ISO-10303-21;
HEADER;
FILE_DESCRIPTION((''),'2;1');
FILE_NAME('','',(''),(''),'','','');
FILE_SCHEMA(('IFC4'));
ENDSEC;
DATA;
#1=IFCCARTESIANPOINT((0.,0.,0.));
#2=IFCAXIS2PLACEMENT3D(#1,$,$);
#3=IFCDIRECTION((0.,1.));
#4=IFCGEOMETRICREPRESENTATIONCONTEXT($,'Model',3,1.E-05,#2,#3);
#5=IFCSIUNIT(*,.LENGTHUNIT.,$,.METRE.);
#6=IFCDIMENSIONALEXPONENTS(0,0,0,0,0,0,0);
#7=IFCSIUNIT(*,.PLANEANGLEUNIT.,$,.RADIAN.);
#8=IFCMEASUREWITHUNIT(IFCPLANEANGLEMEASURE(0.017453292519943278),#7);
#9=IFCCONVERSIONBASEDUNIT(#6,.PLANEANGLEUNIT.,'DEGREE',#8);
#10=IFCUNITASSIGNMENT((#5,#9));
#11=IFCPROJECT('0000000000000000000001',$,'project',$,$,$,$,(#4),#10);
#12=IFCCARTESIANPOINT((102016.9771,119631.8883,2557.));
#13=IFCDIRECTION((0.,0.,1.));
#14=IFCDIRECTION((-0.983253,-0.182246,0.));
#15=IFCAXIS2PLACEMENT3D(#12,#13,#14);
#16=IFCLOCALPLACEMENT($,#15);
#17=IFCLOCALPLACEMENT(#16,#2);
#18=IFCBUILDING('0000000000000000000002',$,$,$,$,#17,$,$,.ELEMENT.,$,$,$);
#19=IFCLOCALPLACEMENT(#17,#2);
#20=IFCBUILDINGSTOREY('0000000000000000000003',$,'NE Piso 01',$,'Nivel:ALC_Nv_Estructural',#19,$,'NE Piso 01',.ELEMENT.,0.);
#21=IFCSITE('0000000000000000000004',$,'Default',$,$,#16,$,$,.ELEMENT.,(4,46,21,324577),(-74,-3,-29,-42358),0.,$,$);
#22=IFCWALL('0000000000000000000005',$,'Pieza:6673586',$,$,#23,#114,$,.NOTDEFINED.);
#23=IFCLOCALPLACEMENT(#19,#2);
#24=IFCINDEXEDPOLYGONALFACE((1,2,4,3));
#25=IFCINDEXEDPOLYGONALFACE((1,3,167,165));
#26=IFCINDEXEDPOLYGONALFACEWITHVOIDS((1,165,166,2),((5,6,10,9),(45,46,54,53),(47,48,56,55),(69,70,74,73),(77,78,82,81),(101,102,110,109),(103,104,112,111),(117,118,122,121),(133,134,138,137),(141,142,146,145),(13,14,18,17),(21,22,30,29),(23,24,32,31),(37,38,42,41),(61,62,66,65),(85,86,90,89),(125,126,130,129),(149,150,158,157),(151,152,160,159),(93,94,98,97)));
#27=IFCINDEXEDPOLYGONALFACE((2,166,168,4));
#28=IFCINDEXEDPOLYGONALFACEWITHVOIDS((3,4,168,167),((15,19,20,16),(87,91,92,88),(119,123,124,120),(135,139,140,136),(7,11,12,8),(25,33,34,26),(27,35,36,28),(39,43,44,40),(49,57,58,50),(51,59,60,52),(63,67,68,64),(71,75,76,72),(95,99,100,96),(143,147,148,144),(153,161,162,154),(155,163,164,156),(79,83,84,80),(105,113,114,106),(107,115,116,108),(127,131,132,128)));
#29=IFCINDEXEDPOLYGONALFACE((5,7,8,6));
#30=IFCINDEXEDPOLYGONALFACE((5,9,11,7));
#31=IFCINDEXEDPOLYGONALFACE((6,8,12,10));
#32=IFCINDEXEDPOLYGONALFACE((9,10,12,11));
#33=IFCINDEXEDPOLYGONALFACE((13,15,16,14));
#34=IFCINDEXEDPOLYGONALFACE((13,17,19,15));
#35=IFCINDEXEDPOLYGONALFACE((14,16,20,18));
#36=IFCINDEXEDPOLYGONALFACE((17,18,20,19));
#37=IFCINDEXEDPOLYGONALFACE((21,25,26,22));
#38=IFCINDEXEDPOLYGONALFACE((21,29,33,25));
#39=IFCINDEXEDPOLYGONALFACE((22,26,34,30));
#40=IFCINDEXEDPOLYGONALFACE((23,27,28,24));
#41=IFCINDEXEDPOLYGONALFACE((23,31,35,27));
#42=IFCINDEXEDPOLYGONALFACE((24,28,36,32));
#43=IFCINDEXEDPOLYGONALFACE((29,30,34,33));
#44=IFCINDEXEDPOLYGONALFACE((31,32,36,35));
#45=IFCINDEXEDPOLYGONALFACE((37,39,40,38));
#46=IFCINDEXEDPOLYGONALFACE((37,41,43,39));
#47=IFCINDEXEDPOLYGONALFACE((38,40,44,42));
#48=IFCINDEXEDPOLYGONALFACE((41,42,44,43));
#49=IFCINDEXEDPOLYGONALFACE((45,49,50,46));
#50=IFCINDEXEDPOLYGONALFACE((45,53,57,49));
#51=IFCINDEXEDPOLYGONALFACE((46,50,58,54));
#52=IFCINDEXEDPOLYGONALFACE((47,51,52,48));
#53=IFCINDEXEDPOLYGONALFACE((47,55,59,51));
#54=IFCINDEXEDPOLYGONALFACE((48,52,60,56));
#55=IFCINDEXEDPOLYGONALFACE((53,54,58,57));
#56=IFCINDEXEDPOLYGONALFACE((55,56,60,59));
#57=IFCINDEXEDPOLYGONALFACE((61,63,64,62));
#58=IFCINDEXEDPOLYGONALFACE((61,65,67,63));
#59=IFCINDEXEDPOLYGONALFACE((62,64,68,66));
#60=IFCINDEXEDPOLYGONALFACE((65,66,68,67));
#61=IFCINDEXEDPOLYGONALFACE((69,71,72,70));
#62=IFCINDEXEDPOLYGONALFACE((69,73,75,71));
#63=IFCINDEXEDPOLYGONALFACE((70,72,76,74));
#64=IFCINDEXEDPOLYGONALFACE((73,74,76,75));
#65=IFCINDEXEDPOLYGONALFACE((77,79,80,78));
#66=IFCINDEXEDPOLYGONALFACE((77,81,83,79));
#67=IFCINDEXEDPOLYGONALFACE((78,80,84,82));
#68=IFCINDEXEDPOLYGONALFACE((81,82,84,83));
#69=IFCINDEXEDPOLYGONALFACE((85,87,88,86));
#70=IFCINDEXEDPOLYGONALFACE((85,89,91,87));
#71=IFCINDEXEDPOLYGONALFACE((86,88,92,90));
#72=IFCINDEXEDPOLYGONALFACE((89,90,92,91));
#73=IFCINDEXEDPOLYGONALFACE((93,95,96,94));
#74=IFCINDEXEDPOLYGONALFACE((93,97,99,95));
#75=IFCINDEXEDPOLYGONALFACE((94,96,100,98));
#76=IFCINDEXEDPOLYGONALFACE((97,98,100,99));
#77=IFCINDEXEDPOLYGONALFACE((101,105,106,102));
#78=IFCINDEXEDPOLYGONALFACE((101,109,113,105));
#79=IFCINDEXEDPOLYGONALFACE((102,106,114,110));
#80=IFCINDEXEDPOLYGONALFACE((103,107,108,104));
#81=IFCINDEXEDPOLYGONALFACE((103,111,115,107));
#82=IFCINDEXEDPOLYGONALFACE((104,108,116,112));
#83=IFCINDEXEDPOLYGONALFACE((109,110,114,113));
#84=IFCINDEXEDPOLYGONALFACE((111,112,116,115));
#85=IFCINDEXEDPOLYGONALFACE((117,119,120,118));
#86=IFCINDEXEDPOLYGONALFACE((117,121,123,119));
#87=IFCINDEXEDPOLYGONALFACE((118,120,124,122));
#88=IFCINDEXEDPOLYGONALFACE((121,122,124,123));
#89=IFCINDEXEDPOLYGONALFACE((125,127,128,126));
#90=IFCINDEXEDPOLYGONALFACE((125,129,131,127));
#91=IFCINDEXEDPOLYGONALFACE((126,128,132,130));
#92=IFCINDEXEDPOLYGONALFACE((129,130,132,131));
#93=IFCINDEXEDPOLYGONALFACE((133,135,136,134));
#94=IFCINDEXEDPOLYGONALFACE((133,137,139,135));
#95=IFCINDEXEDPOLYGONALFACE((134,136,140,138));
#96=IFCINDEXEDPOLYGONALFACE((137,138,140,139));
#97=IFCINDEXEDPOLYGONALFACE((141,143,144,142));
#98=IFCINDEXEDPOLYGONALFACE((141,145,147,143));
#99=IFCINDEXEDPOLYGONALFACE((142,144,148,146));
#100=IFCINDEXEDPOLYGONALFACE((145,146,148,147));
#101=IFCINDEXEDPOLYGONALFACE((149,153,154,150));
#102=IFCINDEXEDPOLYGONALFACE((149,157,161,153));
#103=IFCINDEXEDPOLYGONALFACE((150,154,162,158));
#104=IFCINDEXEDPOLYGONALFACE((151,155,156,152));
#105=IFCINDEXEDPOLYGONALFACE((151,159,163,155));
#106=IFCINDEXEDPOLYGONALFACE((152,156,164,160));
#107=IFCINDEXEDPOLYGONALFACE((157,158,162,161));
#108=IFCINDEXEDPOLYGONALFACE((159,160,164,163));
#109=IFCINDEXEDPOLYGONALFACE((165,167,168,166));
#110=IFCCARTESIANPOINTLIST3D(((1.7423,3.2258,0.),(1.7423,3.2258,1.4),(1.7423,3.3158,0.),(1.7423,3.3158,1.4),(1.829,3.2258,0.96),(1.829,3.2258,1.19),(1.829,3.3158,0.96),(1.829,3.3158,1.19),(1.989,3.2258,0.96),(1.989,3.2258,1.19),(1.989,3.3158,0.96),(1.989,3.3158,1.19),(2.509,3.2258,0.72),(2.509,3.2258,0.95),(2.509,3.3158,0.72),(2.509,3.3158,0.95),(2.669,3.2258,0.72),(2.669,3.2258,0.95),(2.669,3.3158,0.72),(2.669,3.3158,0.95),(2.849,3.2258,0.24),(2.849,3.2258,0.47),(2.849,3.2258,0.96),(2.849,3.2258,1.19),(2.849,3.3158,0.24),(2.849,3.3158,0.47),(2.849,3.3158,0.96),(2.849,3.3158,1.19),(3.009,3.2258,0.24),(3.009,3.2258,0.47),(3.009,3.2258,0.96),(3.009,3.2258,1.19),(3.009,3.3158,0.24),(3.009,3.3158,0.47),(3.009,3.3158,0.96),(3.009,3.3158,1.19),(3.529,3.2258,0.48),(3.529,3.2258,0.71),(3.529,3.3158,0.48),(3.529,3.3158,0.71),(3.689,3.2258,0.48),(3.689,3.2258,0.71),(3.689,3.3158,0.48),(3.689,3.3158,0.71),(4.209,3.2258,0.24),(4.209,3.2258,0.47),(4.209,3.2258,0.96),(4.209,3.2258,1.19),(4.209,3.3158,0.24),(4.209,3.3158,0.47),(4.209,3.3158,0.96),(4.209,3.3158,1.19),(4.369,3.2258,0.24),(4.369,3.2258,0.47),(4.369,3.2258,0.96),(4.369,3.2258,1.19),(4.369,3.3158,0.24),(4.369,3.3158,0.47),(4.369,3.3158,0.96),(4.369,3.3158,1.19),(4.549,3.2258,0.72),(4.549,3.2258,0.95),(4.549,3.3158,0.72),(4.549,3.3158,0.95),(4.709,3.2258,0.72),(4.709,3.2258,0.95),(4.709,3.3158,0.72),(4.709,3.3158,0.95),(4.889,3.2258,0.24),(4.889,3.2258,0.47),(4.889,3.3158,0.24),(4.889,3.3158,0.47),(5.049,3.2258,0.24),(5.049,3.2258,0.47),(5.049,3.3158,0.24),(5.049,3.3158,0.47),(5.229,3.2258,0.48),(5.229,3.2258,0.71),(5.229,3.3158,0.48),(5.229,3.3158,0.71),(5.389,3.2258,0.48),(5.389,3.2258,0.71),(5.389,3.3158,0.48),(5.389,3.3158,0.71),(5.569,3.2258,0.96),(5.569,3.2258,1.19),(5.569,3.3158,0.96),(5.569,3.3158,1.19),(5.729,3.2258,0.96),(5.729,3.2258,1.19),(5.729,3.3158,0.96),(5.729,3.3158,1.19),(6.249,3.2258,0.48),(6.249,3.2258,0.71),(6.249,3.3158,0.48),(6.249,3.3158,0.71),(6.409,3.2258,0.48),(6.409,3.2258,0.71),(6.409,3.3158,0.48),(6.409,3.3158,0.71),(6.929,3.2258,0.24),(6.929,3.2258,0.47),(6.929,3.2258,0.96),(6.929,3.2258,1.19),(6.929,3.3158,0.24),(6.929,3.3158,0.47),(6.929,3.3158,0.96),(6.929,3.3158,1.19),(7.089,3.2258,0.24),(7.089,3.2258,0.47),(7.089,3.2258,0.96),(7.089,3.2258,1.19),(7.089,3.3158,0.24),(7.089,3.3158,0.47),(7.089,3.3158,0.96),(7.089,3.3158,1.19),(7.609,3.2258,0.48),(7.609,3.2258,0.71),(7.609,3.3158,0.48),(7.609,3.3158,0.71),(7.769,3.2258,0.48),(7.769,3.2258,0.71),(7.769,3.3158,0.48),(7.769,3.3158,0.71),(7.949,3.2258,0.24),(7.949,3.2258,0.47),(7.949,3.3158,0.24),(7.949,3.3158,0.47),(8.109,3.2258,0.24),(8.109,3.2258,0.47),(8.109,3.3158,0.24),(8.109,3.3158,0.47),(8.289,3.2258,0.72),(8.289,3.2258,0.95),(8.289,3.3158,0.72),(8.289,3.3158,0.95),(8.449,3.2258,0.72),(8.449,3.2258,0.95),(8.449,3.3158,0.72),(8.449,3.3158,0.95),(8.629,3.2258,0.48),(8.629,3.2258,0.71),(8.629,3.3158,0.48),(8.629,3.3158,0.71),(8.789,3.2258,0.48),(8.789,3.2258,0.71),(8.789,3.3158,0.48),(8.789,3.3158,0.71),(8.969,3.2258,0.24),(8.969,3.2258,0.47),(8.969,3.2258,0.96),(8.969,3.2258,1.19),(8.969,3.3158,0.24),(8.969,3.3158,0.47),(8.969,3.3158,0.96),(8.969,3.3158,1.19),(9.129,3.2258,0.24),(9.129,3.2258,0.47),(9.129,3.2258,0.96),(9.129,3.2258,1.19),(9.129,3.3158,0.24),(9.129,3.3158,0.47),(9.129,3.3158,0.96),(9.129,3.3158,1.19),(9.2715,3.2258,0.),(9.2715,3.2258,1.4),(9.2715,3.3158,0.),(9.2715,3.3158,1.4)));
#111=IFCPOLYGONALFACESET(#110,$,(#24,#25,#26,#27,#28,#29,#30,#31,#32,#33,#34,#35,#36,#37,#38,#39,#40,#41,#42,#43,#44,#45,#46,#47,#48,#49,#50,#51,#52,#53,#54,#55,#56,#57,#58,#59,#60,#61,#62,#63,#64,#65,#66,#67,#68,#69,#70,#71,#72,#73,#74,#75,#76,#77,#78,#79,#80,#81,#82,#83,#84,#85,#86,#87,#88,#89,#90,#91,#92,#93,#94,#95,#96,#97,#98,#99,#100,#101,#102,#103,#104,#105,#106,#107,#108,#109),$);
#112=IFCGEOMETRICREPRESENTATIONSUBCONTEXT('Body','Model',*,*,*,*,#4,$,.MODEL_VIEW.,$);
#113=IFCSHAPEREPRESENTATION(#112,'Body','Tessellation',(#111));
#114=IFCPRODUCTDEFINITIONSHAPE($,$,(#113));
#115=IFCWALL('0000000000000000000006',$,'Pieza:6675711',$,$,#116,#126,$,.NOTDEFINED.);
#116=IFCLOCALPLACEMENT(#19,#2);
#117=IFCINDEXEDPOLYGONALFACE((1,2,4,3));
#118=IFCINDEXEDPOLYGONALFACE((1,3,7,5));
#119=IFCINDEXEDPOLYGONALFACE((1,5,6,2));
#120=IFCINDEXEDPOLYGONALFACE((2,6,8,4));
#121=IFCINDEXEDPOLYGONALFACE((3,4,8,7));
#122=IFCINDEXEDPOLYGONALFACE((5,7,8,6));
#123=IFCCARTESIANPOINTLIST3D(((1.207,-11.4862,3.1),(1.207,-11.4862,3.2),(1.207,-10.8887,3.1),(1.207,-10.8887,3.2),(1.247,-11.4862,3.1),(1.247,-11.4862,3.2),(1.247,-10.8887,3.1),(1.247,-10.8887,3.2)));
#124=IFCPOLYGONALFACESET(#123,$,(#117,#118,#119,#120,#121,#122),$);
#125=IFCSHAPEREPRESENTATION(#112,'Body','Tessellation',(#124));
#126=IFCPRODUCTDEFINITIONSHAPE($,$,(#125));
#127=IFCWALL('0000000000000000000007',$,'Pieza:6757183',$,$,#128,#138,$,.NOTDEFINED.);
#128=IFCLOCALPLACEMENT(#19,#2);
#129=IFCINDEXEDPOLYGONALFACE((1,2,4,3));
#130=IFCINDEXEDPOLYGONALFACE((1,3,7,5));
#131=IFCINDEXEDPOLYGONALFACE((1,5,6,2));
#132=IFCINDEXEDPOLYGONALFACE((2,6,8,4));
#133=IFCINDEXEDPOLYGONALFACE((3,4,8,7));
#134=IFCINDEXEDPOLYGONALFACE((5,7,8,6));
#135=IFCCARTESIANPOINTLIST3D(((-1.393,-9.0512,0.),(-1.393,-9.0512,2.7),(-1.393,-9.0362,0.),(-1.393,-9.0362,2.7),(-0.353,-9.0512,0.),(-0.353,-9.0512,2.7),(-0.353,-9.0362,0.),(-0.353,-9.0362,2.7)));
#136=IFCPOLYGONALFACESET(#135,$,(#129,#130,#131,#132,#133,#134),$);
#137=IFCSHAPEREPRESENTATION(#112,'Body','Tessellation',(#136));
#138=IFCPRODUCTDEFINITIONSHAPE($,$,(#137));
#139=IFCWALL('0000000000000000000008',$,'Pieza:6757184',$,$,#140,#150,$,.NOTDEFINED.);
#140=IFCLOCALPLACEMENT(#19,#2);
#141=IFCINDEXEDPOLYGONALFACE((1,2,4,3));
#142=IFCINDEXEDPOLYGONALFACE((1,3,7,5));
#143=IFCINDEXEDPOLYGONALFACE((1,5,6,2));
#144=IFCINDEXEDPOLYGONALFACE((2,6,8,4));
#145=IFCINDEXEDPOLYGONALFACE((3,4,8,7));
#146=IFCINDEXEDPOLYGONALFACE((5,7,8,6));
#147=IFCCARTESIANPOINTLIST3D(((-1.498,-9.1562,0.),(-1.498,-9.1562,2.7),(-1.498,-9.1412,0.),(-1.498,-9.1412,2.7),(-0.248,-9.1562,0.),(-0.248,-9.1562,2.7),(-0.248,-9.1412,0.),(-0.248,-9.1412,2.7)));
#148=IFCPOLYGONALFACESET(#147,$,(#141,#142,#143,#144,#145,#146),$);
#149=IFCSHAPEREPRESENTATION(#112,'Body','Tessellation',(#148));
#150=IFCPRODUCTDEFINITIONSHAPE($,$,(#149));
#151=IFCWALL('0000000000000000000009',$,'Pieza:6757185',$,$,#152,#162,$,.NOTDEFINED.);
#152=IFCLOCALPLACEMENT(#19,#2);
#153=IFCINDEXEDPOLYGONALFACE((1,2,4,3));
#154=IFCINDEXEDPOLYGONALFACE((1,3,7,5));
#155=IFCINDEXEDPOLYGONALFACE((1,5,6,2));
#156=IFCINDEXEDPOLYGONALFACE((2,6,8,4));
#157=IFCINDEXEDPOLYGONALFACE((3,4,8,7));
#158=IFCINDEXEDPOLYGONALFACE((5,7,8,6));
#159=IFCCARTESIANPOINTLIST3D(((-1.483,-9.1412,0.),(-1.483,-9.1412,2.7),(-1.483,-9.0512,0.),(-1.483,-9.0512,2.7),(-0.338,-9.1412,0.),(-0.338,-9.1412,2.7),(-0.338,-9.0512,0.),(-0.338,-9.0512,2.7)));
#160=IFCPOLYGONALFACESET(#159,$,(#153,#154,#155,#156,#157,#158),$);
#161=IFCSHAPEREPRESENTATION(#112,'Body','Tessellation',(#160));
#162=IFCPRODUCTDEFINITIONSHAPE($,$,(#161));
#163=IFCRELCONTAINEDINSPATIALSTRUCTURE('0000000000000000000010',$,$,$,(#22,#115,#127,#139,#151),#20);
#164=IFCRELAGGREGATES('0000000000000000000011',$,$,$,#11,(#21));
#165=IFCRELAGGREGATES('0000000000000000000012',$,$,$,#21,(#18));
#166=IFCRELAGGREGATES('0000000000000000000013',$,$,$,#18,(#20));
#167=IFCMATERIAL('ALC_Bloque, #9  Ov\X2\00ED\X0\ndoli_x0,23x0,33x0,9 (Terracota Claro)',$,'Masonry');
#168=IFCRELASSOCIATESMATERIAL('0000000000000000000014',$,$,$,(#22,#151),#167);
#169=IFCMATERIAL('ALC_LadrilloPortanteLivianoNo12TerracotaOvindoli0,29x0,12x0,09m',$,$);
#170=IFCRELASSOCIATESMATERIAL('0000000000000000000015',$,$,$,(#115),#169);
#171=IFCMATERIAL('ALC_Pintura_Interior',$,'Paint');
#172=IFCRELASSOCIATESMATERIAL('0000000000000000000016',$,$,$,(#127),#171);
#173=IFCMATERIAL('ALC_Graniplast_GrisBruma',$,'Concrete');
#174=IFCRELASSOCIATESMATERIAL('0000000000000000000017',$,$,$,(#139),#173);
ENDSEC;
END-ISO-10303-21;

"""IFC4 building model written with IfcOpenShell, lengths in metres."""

from ifc_helpers import new_model, entity, si_unit, converted_unit, direction, frame, frame_2d, origin, place, context, subcontext, project, spatial, rectangle, extrude, boolean, material, element, save


model = new_model("IFC4")

# Units and contexts
model_context = context("Model", 3, precision=1e-05, world=origin(), true_north=direction((0.0, 1.0)))
body_context = subcontext(model_context, "Body", "Model", "MODEL_VIEW")
ifc_project = project(units=[si_unit("LENGTHUNIT", "METRE"), converted_unit("PLANEANGLEUNIT", "DEGREE", entity("IfcPlaneAngleMeasure", 0.017453292519943278), si_unit("PLANEANGLEUNIT", "RADIAN"), dimensions=[0, 0, 0, 0, 0, 0, 0])], contexts=[model_context])

# Site, building, storey
site_placement = place(None, frame((102016.9771, 119631.8883, 2557.0), z_axis=(0.0, 0.0, 1.0), x_axis=(-0.983253, -0.182246, 0.0)))
site = spatial("IfcSite", under=ifc_project, at=site_placement, Name="Default", CompositionType="ELEMENT", RefLatitude=(4, 46, 21, 324577), RefLongitude=(-74, -3, -29, -42358), RefElevation=0.0)
building_placement = place(site_placement, origin())
building = spatial("IfcBuilding", under=site, at=building_placement, CompositionType="ELEMENT")
storey_placement = place(building_placement, origin())
storey = spatial("IfcBuildingStorey", under=building, at=storey_placement, Name="NE Piso 01", ObjectType="Nivel:ALC_Nv_Estructural", LongName="NE Piso 01", CompositionType="ELEMENT", Elevation=0.0)

# Shared definitions
ifc_material_1 = material(Name="ALC_Pintura_Interior", Category="Paint")

# Shared definitions
ifc_material_2 = material(Name="ALC_Bloque, #9  Ovíndoli_x0,23x0,33x0,9 (Terracota Claro)", Category="Masonry")

# Walls
ifc_material_3 = material(Name="ALC_Graniplast_GrisBruma", Category="Concrete")
wall_1_placement = place(storey_placement, origin())
solid_1 = boolean("DIFFERENCE", boolean("DIFFERENCE", boolean("DIFFERENCE", boolean("DIFFERENCE", boolean("DIFFERENCE", boolean("DIFFERENCE", boolean("DIFFERENCE", boolean("DIFFERENCE", extrude(rectangle(XDim=0.09, YDim=7.5292, at=frame_2d((0.0, 0.0), x_axis=(1.0, 0.0))), frame((5.5069, 3.2708, 0.0), z_axis=(0.0, 0.0, 1.0), x_axis=(0.0, -1.0, 0.0)), (0.0, 0.0, 1.0), 1.4), extrude(rectangle(XDim=0.23, YDim=0.16, at=frame_2d((0.0, 0.0), x_axis=(0.0, 1.0))), frame((2.929, 3.3158, 0.355), z_axis=(0.0, -1.0, 0.0), x_axis=(-1.0, 0.0, 0.0)), (0.0, 0.0, 1.0), 0.09)), extrude(rectangle(XDim=0.23, YDim=0.16, at=frame_2d((0.0, 0.0), x_axis=(0.0, 1.0))), frame((4.289, 3.3158, 0.355), z_axis=(0.0, -1.0, 0.0), x_axis=(-1.0, 0.0, 0.0)), (0.0, 0.0, 1.0), 0.09)), extrude(rectangle(XDim=0.23, YDim=0.16, at=frame_2d((0.0, 0.0), x_axis=(0.0, 1.0))), frame((4.969, 3.3158, 0.355), z_axis=(0.0, -1.0, 0.0), x_axis=(-1.0, 0.0, 0.0)), (0.0, 0.0, 1.0), 0.09)), extrude(rectangle(XDim=0.23, YDim=0.16, at=frame_2d((0.0, 0.0), x_axis=(0.0, 1.0))), frame((7.009, 3.3158, 0.355), z_axis=(0.0, -1.0, 0.0), x_axis=(-1.0, 0.0, 0.0)), (0.0, 0.0, 1.0), 0.09)), extrude(rectangle(XDim=0.23, YDim=0.16, at=frame_2d((0.0, 0.0), x_axis=(0.0, 1.0))), frame((8.029, 3.3158, 0.355), z_axis=(0.0, -1.0, 0.0), x_axis=(-1.0, 0.0, 0.0)), (0.0, 0.0, 1.0), 0.09)), extrude(rectangle(XDim=0.23, YDim=0.16, at=frame_2d((0.0, 0.0), x_axis=(0.0, 1.0))), frame((9.049, 3.3158, 0.355), z_axis=(0.0, -1.0, 0.0), x_axis=(-1.0, 0.0, 0.0)), (0.0, 0.0, 1.0), 0.09)), extrude(rectangle(XDim=0.23, YDim=0.16, at=frame_2d((0.0, 0.0), x_axis=(0.0, 1.0))), frame((3.609, 3.3158, 0.595), z_axis=(0.0, -1.0, 0.0), x_axis=(-1.0, 0.0, 0.0)), (0.0, 0.0, 1.0), 0.09)), extrude(rectangle(XDim=0.23, YDim=0.16, at=frame_2d((0.0, 0.0), x_axis=(0.0, 1.0))), frame((5.309, 3.3158, 0.595), z_axis=(0.0, -1.0, 0.0), x_axis=(-1.0, 0.0, 0.0)), (0.0, 0.0, 1.0), 0.09))
solid_2 = boolean("DIFFERENCE", boolean("DIFFERENCE", boolean("DIFFERENCE", boolean("DIFFERENCE", boolean("DIFFERENCE", boolean("DIFFERENCE", boolean("DIFFERENCE", boolean("DIFFERENCE", solid_1, extrude(rectangle(XDim=0.23, YDim=0.16, at=frame_2d((0.0, 0.0), x_axis=(0.0, 1.0))), frame((6.329, 3.3158, 0.595), z_axis=(0.0, -1.0, 0.0), x_axis=(-1.0, 0.0, 0.0)), (0.0, 0.0, 1.0), 0.09)), extrude(rectangle(XDim=0.23, YDim=0.16, at=frame_2d((0.0, 0.0), x_axis=(0.0, 1.0))), frame((7.689, 3.3158, 0.595), z_axis=(0.0, -1.0, 0.0), x_axis=(-1.0, 0.0, 0.0)), (0.0, 0.0, 1.0), 0.09)), extrude(rectangle(XDim=0.23, YDim=0.16, at=frame_2d((0.0, 0.0), x_axis=(0.0, 1.0))), frame((8.709, 3.3158, 0.595), z_axis=(0.0, -1.0, 0.0), x_axis=(-1.0, 0.0, 0.0)), (0.0, 0.0, 1.0), 0.09)), extrude(rectangle(XDim=0.23, YDim=0.16, at=frame_2d((0.0, 0.0), x_axis=(0.0, 1.0))), frame((2.589, 3.3158, 0.835), z_axis=(0.0, -1.0, 0.0), x_axis=(-1.0, 0.0, 0.0)), (0.0, 0.0, 1.0), 0.09)), extrude(rectangle(XDim=0.23, YDim=0.16, at=frame_2d((0.0, 0.0), x_axis=(0.0, 1.0))), frame((4.629, 3.3158, 0.835), z_axis=(0.0, -1.0, 0.0), x_axis=(-1.0, 0.0, 0.0)), (0.0, 0.0, 1.0), 0.09)), extrude(rectangle(XDim=0.23, YDim=0.16, at=frame_2d((0.0, 0.0), x_axis=(0.0, 1.0))), frame((8.369, 3.3158, 0.835), z_axis=(0.0, -1.0, 0.0), x_axis=(-1.0, 0.0, 0.0)), (0.0, 0.0, 1.0), 0.09)), extrude(rectangle(XDim=0.23, YDim=0.16, at=frame_2d((0.0, 0.0), x_axis=(0.0, 1.0))), frame((1.909, 3.3158, 1.075), z_axis=(0.0, -1.0, 0.0), x_axis=(-1.0, 0.0, 0.0)), (0.0, 0.0, 1.0), 0.09)), extrude(rectangle(XDim=0.23, YDim=0.16, at=frame_2d((0.0, 0.0), x_axis=(0.0, 1.0))), frame((2.929, 3.3158, 1.075), z_axis=(0.0, -1.0, 0.0), x_axis=(-1.0, 0.0, 0.0)), (0.0, 0.0, 1.0), 0.09))
element("IfcWall", 1, at=wall_1_placement, inside=storey, material=ifc_material_2, Name="Pieza:6673586", PredefinedType="NOTDEFINED", context=body_context, shape_type="SweptSolid", body=[
    boolean("DIFFERENCE", boolean("DIFFERENCE", boolean("DIFFERENCE", boolean("DIFFERENCE", solid_2, extrude(rectangle(XDim=0.23, YDim=0.16, at=frame_2d((0.0, 0.0), x_axis=(0.0, 1.0))), frame((4.289, 3.3158, 1.075), z_axis=(0.0, -1.0, 0.0), x_axis=(-1.0, 0.0, 0.0)), (0.0, 0.0, 1.0), 0.09)), extrude(rectangle(XDim=0.23, YDim=0.16, at=frame_2d((0.0, 0.0), x_axis=(0.0, 1.0))), frame((5.649, 3.3158, 1.075), z_axis=(0.0, -1.0, 0.0), x_axis=(-1.0, 0.0, 0.0)), (0.0, 0.0, 1.0), 0.09)), extrude(rectangle(XDim=0.23, YDim=0.16, at=frame_2d((0.0, 0.0), x_axis=(0.0, 1.0))), frame((7.009, 3.3158, 1.075), z_axis=(0.0, -1.0, 0.0), x_axis=(-1.0, 0.0, 0.0)), (0.0, 0.0, 1.0), 0.09)), extrude(rectangle(XDim=0.23, YDim=0.16, at=frame_2d((0.0, 0.0), x_axis=(0.0, 1.0))), frame((9.049, 3.2258, 1.075), z_axis=(0.0, 1.0, 0.0), x_axis=(1.0, 0.0, 0.0)), (0.0, 0.0, 1.0), 0.09)),
])
ifc_material_4 = material(Name="ALC_LadrilloPortanteLivianoNo12TerracotaOvindoli0,29x0,12x0,09m")
wall_2_placement = place(storey_placement, frame((0.0, 0.0, 3.1)))
element("IfcWall", 2, at=wall_2_placement, inside=storey, material=ifc_material_4, Name="Pieza:6675711", PredefinedType="NOTDEFINED", context=body_context, shape_type="SweptSolid", body=[
    extrude(rectangle(XDim=0.5975, YDim=0.04, at=frame_2d((0.0, 0.0), x_axis=(1.0, 0.0))), frame((1.227, -11.1874, 0.0), z_axis=(0.0, 0.0, 1.0), x_axis=(0.0, -1.0, 0.0)), (0.0, 0.0, 1.0), 0.1),
])
wall_3_placement = place(storey_placement, origin())
element("IfcWall", 3, at=wall_3_placement, inside=storey, material=ifc_material_1, Name="Pieza:6757183", PredefinedType="NOTDEFINED", context=body_context, shape_type="SweptSolid", body=[
    extrude(rectangle(XDim=0.015, YDim=1.04, at=frame_2d((0.0, 0.0), x_axis=(1.0, 0.0))), frame((-0.873, -9.0437, 0.0), z_axis=(0.0, 0.0, 1.0), x_axis=(0.0, -1.0, 0.0)), (0.0, 0.0, 1.0), 2.7),
])
wall_4_placement = place(storey_placement, origin())
element("IfcWall", 4, at=wall_4_placement, inside=storey, material=ifc_material_3, Name="Pieza:6757184", PredefinedType="NOTDEFINED", context=body_context, shape_type="SweptSolid", body=[
    extrude(rectangle(XDim=0.015, YDim=1.25, at=frame_2d((0.0, 0.0), x_axis=(1.0, 0.0))), frame((-0.873, -9.1487, 0.0), z_axis=(0.0, 0.0, 1.0), x_axis=(0.0, -1.0, 0.0)), (0.0, 0.0, 1.0), 2.7),
])
wall_5_placement = place(storey_placement, origin())
element("IfcWall", 5, at=wall_5_placement, inside=storey, material=ifc_material_2, Name="Pieza:6757185", PredefinedType="NOTDEFINED", context=body_context, shape_type="SweptSolid", body=[
    extrude(rectangle(XDim=0.09, YDim=1.145, at=frame_2d((0.0, 0.0), x_axis=(1.0, 0.0))), frame((-0.9105, -9.0962, 0.0), z_axis=(0.0, 0.0, 1.0), x_axis=(0.0, -1.0, 0.0)), (0.0, 0.0, 1.0), 2.7),
])

save(model, "model.ifc")
